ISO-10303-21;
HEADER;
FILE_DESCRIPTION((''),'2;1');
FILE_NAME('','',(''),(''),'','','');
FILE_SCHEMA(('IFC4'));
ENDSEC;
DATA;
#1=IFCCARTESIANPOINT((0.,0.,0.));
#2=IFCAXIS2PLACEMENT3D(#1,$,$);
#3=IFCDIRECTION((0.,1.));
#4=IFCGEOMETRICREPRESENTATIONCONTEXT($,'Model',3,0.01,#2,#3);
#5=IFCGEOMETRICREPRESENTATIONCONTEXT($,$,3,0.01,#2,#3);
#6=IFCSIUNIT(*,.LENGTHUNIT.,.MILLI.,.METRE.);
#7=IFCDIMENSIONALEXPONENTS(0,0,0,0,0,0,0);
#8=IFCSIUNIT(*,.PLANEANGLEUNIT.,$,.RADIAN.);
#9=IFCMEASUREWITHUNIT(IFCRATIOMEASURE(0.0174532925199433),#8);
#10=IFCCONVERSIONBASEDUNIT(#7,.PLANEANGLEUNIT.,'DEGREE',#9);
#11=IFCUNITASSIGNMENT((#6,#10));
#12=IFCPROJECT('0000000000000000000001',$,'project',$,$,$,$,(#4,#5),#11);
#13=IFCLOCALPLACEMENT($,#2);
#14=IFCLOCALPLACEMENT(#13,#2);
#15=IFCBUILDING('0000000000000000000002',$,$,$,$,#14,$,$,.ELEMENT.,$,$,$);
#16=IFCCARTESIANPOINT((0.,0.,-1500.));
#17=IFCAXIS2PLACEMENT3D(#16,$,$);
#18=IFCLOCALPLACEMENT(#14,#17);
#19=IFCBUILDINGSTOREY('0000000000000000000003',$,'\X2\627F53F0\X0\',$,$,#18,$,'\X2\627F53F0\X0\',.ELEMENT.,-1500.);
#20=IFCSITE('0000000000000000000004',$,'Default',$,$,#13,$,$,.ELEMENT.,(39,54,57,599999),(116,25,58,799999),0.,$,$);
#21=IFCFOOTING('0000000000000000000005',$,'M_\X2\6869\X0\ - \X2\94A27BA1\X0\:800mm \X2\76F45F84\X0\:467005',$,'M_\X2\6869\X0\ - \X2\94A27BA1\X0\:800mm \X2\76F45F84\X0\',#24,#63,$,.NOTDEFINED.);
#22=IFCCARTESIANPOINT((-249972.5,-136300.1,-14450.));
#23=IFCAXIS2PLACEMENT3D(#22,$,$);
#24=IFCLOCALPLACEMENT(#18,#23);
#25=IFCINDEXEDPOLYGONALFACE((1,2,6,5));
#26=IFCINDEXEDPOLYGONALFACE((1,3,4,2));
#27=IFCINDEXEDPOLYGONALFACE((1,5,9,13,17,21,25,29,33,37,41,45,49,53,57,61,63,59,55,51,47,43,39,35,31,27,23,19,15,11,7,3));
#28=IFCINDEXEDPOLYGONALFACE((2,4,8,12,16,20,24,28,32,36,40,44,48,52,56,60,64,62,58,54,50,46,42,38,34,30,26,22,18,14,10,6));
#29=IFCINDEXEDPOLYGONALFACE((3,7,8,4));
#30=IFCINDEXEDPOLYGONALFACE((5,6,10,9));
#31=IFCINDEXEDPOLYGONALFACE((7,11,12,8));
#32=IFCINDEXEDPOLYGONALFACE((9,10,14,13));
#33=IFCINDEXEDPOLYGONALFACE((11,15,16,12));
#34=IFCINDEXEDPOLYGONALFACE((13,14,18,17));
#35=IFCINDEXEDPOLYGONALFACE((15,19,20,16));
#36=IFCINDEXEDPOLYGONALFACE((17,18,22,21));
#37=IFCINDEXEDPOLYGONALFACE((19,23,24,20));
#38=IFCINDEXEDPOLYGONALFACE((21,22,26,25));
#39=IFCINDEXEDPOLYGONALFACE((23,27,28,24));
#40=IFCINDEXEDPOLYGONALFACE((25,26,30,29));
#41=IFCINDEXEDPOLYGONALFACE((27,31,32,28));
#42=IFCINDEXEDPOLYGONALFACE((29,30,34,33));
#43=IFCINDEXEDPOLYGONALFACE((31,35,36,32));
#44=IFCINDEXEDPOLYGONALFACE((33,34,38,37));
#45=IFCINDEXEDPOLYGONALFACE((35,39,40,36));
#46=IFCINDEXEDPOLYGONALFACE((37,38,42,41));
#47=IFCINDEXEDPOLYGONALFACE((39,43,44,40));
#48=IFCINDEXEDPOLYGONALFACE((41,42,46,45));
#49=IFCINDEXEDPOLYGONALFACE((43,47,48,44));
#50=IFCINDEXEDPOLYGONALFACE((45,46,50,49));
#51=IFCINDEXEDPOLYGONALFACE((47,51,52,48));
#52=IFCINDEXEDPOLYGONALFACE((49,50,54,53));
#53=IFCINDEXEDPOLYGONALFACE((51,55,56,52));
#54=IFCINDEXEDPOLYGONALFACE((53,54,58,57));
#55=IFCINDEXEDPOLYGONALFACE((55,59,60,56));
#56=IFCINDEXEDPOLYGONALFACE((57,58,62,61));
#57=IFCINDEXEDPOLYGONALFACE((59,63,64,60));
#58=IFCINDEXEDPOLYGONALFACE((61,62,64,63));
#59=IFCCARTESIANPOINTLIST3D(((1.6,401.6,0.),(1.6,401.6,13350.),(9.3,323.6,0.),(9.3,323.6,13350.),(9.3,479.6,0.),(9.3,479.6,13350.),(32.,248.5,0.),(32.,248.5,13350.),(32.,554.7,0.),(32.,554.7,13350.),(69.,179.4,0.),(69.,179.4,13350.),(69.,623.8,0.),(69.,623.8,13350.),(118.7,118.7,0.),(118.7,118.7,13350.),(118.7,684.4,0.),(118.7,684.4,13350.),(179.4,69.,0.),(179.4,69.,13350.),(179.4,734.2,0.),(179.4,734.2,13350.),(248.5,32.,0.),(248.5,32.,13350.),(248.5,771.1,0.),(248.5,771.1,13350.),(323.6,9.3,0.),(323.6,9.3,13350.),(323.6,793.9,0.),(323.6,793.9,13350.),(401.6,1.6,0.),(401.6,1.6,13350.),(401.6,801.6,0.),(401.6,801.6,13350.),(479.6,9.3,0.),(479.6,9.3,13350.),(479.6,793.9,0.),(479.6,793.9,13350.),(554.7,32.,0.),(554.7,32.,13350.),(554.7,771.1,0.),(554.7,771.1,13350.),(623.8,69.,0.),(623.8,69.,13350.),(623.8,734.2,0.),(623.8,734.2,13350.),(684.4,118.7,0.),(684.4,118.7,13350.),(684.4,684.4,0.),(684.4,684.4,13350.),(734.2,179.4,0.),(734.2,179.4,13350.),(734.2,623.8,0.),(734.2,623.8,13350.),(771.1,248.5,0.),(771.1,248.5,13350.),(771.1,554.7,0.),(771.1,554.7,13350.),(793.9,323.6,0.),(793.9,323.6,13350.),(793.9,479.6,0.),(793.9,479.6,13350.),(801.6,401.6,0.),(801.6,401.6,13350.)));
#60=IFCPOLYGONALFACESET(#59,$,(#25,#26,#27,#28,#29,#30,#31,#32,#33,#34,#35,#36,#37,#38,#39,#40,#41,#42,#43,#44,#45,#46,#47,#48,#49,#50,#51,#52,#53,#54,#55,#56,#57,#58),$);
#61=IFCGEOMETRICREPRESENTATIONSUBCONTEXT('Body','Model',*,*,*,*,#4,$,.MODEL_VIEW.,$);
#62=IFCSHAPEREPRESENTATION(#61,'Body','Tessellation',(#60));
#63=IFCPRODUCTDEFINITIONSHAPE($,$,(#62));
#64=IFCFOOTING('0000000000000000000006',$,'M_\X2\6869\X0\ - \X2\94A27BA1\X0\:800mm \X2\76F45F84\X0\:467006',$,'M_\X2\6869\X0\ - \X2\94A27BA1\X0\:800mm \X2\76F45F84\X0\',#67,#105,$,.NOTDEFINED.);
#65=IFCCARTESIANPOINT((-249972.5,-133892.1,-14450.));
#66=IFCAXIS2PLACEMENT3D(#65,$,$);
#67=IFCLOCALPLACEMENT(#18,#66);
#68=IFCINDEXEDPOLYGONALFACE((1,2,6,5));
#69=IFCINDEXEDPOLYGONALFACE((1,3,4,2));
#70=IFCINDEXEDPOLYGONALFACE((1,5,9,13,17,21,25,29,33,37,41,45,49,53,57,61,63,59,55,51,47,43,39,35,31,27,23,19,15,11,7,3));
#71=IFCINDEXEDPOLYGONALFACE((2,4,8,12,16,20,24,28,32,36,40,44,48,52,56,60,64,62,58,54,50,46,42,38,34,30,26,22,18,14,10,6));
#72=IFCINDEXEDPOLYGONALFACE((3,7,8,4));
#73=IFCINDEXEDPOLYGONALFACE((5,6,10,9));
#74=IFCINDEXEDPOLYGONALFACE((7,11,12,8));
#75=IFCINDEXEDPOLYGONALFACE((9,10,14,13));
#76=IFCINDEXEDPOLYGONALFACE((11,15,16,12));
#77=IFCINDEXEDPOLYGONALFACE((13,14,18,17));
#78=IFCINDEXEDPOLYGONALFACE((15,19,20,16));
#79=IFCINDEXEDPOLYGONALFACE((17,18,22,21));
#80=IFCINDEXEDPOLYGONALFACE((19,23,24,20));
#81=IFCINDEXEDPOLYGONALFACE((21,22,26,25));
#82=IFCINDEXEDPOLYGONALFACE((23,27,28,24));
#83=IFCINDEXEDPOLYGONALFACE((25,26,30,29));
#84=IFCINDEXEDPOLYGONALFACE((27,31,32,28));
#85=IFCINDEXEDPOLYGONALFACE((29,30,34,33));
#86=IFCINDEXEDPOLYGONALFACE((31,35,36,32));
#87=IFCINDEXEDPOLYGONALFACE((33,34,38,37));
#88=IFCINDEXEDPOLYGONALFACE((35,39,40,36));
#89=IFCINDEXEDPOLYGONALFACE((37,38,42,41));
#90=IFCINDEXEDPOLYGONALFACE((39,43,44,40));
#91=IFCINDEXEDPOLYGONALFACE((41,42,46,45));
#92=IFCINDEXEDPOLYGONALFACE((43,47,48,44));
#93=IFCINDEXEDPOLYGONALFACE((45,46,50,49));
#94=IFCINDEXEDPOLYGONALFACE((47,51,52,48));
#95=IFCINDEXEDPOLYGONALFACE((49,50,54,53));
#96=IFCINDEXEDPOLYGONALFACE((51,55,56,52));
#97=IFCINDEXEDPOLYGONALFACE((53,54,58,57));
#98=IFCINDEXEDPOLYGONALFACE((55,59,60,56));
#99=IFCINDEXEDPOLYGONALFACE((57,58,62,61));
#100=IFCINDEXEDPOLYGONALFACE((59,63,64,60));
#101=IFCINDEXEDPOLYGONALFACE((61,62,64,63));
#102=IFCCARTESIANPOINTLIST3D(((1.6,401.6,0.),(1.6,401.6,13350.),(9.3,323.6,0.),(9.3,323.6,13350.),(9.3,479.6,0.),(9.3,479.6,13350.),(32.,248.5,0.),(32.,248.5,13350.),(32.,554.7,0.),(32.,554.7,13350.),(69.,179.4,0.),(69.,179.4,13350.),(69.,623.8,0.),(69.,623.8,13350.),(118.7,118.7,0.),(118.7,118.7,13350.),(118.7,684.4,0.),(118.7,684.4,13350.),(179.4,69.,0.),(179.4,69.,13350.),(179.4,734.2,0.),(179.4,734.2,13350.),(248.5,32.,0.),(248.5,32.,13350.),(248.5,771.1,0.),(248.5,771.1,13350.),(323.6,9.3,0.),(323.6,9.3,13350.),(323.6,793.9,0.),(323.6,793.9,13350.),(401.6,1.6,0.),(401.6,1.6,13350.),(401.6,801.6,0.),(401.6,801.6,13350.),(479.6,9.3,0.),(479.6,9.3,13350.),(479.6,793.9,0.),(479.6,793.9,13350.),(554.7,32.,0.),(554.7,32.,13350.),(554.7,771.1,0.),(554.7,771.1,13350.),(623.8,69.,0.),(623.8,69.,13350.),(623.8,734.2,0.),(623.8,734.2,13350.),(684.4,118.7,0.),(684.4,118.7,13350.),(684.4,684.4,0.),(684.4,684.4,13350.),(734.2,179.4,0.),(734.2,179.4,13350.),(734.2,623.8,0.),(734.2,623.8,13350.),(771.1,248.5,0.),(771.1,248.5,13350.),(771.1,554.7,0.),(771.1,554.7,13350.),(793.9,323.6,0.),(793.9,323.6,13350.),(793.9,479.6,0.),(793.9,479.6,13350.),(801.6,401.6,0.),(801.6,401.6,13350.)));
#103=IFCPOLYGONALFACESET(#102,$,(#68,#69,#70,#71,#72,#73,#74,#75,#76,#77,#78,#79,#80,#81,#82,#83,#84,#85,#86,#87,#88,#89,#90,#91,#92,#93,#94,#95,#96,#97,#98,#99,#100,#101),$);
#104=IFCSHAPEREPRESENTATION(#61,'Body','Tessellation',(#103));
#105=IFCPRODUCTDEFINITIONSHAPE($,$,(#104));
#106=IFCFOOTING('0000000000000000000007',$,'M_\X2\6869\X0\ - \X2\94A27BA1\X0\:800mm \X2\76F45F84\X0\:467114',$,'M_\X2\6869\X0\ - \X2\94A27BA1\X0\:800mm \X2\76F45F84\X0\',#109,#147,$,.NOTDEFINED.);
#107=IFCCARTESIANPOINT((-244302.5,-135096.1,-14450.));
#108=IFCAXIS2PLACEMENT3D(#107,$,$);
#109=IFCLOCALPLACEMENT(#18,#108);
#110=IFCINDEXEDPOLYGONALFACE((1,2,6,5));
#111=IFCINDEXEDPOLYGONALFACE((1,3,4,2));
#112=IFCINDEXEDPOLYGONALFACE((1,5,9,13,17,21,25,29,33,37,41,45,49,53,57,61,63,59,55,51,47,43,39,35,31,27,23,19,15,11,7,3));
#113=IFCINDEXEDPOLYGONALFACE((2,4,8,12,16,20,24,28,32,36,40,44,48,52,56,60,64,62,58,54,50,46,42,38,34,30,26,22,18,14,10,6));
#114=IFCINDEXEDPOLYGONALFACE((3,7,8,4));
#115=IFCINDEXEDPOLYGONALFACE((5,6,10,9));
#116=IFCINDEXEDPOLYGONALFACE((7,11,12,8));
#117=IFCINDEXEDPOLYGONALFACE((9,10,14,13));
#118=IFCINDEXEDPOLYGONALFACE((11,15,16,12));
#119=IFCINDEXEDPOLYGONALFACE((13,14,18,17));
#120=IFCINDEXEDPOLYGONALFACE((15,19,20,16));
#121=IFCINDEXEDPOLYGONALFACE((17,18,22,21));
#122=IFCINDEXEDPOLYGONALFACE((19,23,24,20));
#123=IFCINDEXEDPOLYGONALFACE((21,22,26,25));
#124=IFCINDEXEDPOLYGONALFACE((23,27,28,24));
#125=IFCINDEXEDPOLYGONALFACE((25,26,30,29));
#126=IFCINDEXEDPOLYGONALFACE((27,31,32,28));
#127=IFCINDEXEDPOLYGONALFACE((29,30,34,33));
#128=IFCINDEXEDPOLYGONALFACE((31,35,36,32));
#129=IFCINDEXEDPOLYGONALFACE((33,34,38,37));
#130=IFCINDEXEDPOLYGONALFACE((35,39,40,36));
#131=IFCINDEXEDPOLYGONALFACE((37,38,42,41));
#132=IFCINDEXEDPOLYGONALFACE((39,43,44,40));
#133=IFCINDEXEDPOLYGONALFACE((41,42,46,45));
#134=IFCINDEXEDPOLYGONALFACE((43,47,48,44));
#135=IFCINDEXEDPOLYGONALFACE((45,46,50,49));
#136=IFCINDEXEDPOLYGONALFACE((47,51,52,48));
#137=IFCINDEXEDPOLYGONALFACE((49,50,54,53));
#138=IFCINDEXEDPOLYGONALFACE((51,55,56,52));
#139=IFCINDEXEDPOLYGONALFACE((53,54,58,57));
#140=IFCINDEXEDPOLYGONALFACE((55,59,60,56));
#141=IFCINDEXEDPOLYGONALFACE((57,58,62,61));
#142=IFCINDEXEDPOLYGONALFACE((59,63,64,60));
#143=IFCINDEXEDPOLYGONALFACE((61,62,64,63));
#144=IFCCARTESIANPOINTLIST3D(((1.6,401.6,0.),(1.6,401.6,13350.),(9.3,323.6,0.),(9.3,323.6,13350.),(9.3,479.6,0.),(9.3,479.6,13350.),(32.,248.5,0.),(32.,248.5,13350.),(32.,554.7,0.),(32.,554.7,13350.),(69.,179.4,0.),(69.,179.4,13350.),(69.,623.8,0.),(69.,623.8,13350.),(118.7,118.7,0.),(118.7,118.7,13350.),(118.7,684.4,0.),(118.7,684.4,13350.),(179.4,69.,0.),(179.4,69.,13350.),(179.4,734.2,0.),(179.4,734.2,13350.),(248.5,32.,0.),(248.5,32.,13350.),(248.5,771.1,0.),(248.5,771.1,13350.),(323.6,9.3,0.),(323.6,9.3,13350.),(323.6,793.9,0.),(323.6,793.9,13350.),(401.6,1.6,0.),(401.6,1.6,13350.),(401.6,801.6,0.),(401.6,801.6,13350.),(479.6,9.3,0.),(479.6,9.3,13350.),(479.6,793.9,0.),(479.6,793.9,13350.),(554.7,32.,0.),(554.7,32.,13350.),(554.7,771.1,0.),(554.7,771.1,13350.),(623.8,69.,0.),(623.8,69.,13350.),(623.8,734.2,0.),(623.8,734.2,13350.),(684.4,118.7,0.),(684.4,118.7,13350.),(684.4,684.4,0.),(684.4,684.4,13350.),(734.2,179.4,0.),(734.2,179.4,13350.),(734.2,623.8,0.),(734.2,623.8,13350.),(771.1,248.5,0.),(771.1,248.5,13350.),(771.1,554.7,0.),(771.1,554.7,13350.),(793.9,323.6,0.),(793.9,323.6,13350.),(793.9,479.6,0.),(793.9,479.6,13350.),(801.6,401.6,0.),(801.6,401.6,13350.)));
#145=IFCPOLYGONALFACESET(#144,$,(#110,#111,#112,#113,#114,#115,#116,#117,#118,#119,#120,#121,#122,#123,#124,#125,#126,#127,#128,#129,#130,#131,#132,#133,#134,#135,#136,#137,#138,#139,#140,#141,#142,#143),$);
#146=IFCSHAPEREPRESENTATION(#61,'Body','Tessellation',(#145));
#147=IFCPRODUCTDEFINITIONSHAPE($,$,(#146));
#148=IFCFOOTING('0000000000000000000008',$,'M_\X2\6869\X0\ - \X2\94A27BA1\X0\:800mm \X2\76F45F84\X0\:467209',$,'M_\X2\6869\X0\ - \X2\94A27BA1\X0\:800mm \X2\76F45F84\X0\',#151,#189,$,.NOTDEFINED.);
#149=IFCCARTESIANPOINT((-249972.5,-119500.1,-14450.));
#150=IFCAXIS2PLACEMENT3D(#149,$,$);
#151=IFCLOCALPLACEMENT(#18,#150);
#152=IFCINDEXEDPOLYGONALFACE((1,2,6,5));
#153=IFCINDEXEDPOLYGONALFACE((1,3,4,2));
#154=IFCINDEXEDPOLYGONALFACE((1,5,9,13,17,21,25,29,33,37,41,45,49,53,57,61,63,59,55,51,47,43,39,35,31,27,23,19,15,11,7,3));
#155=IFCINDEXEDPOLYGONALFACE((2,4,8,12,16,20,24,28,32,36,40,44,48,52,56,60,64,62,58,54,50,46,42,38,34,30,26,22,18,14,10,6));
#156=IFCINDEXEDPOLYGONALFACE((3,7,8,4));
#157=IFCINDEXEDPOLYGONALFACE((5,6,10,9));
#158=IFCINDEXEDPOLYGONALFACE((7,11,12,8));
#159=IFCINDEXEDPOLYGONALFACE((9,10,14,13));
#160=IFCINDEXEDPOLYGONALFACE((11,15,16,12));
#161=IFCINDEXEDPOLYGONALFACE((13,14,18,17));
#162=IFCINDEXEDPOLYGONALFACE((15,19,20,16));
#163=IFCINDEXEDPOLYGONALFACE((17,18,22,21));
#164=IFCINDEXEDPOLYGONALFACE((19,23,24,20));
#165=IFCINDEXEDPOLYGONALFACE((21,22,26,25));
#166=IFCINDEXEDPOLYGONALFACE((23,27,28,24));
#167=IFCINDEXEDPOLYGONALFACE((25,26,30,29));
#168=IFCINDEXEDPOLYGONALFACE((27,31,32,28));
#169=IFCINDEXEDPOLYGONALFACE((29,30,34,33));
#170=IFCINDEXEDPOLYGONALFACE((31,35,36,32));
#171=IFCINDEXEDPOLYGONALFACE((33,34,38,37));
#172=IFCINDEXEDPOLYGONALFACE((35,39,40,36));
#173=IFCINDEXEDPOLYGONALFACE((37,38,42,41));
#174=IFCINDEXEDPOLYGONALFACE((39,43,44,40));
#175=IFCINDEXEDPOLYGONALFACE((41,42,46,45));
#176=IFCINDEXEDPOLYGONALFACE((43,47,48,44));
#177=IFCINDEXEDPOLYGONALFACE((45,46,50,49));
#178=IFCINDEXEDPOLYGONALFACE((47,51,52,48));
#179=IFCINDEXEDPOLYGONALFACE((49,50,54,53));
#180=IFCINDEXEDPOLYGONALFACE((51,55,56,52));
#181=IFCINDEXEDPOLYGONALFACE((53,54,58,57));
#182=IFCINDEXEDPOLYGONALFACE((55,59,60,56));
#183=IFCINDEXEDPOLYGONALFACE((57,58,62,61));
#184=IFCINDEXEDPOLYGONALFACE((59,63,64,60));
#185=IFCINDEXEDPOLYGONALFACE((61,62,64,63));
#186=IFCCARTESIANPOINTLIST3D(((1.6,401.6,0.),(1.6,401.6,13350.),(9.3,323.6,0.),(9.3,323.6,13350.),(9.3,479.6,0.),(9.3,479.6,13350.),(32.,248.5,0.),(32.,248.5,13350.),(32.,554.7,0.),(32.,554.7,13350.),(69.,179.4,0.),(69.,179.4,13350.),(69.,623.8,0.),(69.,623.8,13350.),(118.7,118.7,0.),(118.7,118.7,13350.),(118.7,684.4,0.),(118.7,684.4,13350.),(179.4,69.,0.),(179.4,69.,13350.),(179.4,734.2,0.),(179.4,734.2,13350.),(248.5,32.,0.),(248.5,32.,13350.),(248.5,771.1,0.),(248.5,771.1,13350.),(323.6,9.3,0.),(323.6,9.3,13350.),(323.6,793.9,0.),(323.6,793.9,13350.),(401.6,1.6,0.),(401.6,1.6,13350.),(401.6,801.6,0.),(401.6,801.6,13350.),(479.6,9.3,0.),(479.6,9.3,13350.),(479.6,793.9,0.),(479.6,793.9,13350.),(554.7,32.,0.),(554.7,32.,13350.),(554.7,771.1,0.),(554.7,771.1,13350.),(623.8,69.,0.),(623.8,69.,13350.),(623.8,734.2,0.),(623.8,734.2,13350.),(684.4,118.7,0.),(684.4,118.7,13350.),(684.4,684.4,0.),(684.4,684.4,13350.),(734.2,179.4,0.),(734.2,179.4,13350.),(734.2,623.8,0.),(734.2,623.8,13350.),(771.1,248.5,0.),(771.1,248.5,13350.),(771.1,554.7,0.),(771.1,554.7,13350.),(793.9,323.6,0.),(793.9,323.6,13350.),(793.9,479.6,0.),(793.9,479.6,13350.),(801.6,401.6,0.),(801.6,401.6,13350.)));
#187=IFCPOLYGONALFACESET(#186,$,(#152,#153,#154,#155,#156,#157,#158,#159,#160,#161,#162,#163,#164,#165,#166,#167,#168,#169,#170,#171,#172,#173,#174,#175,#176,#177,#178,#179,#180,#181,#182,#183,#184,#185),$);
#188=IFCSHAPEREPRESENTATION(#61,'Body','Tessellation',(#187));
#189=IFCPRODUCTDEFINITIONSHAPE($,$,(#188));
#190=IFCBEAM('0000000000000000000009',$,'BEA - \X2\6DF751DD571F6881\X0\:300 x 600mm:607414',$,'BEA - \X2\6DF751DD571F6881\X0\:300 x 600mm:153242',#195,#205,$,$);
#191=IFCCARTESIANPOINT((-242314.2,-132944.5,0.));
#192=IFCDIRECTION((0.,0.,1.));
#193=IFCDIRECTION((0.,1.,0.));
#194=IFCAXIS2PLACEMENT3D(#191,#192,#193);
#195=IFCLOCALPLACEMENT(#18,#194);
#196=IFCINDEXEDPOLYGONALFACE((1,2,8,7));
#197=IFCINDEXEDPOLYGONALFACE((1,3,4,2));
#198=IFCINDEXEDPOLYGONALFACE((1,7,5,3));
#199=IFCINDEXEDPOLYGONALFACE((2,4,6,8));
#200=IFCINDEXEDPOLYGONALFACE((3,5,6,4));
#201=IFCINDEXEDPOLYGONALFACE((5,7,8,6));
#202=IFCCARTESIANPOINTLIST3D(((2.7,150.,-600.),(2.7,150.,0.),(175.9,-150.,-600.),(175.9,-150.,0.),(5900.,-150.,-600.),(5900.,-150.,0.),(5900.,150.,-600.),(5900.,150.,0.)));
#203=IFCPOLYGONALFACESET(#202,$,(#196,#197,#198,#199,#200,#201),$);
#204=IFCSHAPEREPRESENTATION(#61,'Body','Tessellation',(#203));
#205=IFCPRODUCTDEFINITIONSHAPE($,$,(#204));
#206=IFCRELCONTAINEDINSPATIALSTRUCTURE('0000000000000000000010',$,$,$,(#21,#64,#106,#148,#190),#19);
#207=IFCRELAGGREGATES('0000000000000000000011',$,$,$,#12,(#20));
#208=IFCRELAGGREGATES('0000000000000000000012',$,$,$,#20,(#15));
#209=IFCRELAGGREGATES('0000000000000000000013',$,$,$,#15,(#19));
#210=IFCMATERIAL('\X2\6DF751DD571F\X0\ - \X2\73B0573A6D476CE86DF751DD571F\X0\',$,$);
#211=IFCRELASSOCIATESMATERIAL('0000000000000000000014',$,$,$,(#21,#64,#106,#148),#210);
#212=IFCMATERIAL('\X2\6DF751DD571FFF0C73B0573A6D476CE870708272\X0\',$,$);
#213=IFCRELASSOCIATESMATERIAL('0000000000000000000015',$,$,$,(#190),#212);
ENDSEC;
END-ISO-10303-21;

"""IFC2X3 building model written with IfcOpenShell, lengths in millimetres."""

from ifc_helpers import new_model, entity, si_unit, converted_unit, direction, frame, origin, origin_2d_with_axis, place, context, subcontext, project, spatial, rectangle, circle, extrude, clip, halfspace, material, element, save


model = new_model("IFC2X3")

# Units and contexts
model_context = context("Model", 3, precision=0.01, world=origin(), true_north=direction((0.0, 1.0)))
context_of_model = context(None, 3, precision=0.01, world=origin(), true_north=direction((0.0, 1.0)))
body_context = subcontext(model_context, "Body", "Model", "MODEL_VIEW")
ifc_project = project(units=[si_unit("LENGTHUNIT", "METRE", prefix="MILLI"), converted_unit("PLANEANGLEUNIT", "DEGREE", entity("IfcRatioMeasure", 0.0174532925199433), si_unit("PLANEANGLEUNIT", "RADIAN"), dimensions=[0, 0, 0, 0, 0, 0, 0])], contexts=[model_context, context_of_model])

# Site, building, storey
site_placement = place(None, origin())
site = spatial("IfcSite", under=ifc_project, at=site_placement, Name="Default", CompositionType="ELEMENT", RefLatitude=(39, 54, 57, 599999), RefLongitude=(116, 25, 58, 799999), RefElevation=0.0)
building_placement = place(site_placement, origin())
building = spatial("IfcBuilding", under=site, at=building_placement, CompositionType="ELEMENT")
storey_placement = place(building_placement, frame((0.0, 0.0, -1500.0)))
storey = spatial("IfcBuildingStorey", under=building, at=storey_placement, Name="承台", LongName="承台", CompositionType="ELEMENT", Elevation=-1500.0)

# Footings
ifc_material_1 = material(Name="混凝土 - 现场浇注混凝土")
for number, where, name in (
    (1, (-249972.5, -136300.1, -14450.0), "M_桩 - 钢管:800mm 直径:467005"),
    (2, (-249972.5, -133892.1, -14450.0), "M_桩 - 钢管:800mm 直径:467006"),
):
    element("IfcFooting", number, at=place(storey_placement, frame(where)), inside=storey, material=ifc_material_1, Name=name, ObjectType="M_桩 - 钢管:800mm 直径", PredefinedType="NOTDEFINED", context=body_context, shape_type="SweptSolid", body=[
        extrude(circle(Radius=400.0, at=origin_2d_with_axis()), frame((401.6, 401.6, 0.0), z_axis=(0.0, 0.0, 1.0), x_axis=(0.0, 1.0, 0.0)), (0.0, 0.0, 1.0), 13350.0),
    ])
for number, where, name in (
    (3, (-244302.5, -135096.1, -14450.0), "M_桩 - 钢管:800mm 直径:467114"),
    (4, (-249972.5, -119500.1, -14450.0), "M_桩 - 钢管:800mm 直径:467209"),
):
    element("IfcFooting", number, at=place(storey_placement, frame(where)), inside=storey, material=ifc_material_1, Name=name, ObjectType="M_桩 - 钢管:800mm 直径", PredefinedType="NOTDEFINED", context=body_context, shape_type="SweptSolid", body=[
        extrude(circle(Radius=400.0, at=origin_2d_with_axis()), frame((401.6, 401.6, 0.0), z_axis=(0.0, 0.0, 1.0), x_axis=(0.0, 1.0, 0.0)), (0.0, 0.0, 1.0), 13350.0),
    ])

# Shared definitions
ifc_material_2 = material(Name="混凝土，现场浇注灰色")

# Beam
beam_1_placement = place(storey_placement, frame((-242314.2, -132944.5, 0.0), z_axis=(0.0, 0.0, 1.0), x_axis=(0.0, 1.0, 0.0)))
element("IfcBeam", 5, at=beam_1_placement, inside=storey, material=ifc_material_2, Name="BEA - 混凝土梁:300 x 600mm:607414", ObjectType="BEA - 混凝土梁:300 x 600mm:153242", context=body_context, shape_type="Clipping", body=[
    clip(extrude(rectangle(XDim=600.0, YDim=300.0, at=origin_2d_with_axis()), frame((2.7, 0.0, -300.0), z_axis=(1.0, 0.0, 0.0), x_axis=(0.0, 0.0, -1.0)), (0.0, 0.0, 1.0), 5897.3), halfspace(frame((374.0, -493.3, 0.0), z_axis=(-0.866125, -0.499827, 0.0), x_axis=(0.499827, -0.866125, 0.0)), False)),
])

save(model, "model.ifc")
